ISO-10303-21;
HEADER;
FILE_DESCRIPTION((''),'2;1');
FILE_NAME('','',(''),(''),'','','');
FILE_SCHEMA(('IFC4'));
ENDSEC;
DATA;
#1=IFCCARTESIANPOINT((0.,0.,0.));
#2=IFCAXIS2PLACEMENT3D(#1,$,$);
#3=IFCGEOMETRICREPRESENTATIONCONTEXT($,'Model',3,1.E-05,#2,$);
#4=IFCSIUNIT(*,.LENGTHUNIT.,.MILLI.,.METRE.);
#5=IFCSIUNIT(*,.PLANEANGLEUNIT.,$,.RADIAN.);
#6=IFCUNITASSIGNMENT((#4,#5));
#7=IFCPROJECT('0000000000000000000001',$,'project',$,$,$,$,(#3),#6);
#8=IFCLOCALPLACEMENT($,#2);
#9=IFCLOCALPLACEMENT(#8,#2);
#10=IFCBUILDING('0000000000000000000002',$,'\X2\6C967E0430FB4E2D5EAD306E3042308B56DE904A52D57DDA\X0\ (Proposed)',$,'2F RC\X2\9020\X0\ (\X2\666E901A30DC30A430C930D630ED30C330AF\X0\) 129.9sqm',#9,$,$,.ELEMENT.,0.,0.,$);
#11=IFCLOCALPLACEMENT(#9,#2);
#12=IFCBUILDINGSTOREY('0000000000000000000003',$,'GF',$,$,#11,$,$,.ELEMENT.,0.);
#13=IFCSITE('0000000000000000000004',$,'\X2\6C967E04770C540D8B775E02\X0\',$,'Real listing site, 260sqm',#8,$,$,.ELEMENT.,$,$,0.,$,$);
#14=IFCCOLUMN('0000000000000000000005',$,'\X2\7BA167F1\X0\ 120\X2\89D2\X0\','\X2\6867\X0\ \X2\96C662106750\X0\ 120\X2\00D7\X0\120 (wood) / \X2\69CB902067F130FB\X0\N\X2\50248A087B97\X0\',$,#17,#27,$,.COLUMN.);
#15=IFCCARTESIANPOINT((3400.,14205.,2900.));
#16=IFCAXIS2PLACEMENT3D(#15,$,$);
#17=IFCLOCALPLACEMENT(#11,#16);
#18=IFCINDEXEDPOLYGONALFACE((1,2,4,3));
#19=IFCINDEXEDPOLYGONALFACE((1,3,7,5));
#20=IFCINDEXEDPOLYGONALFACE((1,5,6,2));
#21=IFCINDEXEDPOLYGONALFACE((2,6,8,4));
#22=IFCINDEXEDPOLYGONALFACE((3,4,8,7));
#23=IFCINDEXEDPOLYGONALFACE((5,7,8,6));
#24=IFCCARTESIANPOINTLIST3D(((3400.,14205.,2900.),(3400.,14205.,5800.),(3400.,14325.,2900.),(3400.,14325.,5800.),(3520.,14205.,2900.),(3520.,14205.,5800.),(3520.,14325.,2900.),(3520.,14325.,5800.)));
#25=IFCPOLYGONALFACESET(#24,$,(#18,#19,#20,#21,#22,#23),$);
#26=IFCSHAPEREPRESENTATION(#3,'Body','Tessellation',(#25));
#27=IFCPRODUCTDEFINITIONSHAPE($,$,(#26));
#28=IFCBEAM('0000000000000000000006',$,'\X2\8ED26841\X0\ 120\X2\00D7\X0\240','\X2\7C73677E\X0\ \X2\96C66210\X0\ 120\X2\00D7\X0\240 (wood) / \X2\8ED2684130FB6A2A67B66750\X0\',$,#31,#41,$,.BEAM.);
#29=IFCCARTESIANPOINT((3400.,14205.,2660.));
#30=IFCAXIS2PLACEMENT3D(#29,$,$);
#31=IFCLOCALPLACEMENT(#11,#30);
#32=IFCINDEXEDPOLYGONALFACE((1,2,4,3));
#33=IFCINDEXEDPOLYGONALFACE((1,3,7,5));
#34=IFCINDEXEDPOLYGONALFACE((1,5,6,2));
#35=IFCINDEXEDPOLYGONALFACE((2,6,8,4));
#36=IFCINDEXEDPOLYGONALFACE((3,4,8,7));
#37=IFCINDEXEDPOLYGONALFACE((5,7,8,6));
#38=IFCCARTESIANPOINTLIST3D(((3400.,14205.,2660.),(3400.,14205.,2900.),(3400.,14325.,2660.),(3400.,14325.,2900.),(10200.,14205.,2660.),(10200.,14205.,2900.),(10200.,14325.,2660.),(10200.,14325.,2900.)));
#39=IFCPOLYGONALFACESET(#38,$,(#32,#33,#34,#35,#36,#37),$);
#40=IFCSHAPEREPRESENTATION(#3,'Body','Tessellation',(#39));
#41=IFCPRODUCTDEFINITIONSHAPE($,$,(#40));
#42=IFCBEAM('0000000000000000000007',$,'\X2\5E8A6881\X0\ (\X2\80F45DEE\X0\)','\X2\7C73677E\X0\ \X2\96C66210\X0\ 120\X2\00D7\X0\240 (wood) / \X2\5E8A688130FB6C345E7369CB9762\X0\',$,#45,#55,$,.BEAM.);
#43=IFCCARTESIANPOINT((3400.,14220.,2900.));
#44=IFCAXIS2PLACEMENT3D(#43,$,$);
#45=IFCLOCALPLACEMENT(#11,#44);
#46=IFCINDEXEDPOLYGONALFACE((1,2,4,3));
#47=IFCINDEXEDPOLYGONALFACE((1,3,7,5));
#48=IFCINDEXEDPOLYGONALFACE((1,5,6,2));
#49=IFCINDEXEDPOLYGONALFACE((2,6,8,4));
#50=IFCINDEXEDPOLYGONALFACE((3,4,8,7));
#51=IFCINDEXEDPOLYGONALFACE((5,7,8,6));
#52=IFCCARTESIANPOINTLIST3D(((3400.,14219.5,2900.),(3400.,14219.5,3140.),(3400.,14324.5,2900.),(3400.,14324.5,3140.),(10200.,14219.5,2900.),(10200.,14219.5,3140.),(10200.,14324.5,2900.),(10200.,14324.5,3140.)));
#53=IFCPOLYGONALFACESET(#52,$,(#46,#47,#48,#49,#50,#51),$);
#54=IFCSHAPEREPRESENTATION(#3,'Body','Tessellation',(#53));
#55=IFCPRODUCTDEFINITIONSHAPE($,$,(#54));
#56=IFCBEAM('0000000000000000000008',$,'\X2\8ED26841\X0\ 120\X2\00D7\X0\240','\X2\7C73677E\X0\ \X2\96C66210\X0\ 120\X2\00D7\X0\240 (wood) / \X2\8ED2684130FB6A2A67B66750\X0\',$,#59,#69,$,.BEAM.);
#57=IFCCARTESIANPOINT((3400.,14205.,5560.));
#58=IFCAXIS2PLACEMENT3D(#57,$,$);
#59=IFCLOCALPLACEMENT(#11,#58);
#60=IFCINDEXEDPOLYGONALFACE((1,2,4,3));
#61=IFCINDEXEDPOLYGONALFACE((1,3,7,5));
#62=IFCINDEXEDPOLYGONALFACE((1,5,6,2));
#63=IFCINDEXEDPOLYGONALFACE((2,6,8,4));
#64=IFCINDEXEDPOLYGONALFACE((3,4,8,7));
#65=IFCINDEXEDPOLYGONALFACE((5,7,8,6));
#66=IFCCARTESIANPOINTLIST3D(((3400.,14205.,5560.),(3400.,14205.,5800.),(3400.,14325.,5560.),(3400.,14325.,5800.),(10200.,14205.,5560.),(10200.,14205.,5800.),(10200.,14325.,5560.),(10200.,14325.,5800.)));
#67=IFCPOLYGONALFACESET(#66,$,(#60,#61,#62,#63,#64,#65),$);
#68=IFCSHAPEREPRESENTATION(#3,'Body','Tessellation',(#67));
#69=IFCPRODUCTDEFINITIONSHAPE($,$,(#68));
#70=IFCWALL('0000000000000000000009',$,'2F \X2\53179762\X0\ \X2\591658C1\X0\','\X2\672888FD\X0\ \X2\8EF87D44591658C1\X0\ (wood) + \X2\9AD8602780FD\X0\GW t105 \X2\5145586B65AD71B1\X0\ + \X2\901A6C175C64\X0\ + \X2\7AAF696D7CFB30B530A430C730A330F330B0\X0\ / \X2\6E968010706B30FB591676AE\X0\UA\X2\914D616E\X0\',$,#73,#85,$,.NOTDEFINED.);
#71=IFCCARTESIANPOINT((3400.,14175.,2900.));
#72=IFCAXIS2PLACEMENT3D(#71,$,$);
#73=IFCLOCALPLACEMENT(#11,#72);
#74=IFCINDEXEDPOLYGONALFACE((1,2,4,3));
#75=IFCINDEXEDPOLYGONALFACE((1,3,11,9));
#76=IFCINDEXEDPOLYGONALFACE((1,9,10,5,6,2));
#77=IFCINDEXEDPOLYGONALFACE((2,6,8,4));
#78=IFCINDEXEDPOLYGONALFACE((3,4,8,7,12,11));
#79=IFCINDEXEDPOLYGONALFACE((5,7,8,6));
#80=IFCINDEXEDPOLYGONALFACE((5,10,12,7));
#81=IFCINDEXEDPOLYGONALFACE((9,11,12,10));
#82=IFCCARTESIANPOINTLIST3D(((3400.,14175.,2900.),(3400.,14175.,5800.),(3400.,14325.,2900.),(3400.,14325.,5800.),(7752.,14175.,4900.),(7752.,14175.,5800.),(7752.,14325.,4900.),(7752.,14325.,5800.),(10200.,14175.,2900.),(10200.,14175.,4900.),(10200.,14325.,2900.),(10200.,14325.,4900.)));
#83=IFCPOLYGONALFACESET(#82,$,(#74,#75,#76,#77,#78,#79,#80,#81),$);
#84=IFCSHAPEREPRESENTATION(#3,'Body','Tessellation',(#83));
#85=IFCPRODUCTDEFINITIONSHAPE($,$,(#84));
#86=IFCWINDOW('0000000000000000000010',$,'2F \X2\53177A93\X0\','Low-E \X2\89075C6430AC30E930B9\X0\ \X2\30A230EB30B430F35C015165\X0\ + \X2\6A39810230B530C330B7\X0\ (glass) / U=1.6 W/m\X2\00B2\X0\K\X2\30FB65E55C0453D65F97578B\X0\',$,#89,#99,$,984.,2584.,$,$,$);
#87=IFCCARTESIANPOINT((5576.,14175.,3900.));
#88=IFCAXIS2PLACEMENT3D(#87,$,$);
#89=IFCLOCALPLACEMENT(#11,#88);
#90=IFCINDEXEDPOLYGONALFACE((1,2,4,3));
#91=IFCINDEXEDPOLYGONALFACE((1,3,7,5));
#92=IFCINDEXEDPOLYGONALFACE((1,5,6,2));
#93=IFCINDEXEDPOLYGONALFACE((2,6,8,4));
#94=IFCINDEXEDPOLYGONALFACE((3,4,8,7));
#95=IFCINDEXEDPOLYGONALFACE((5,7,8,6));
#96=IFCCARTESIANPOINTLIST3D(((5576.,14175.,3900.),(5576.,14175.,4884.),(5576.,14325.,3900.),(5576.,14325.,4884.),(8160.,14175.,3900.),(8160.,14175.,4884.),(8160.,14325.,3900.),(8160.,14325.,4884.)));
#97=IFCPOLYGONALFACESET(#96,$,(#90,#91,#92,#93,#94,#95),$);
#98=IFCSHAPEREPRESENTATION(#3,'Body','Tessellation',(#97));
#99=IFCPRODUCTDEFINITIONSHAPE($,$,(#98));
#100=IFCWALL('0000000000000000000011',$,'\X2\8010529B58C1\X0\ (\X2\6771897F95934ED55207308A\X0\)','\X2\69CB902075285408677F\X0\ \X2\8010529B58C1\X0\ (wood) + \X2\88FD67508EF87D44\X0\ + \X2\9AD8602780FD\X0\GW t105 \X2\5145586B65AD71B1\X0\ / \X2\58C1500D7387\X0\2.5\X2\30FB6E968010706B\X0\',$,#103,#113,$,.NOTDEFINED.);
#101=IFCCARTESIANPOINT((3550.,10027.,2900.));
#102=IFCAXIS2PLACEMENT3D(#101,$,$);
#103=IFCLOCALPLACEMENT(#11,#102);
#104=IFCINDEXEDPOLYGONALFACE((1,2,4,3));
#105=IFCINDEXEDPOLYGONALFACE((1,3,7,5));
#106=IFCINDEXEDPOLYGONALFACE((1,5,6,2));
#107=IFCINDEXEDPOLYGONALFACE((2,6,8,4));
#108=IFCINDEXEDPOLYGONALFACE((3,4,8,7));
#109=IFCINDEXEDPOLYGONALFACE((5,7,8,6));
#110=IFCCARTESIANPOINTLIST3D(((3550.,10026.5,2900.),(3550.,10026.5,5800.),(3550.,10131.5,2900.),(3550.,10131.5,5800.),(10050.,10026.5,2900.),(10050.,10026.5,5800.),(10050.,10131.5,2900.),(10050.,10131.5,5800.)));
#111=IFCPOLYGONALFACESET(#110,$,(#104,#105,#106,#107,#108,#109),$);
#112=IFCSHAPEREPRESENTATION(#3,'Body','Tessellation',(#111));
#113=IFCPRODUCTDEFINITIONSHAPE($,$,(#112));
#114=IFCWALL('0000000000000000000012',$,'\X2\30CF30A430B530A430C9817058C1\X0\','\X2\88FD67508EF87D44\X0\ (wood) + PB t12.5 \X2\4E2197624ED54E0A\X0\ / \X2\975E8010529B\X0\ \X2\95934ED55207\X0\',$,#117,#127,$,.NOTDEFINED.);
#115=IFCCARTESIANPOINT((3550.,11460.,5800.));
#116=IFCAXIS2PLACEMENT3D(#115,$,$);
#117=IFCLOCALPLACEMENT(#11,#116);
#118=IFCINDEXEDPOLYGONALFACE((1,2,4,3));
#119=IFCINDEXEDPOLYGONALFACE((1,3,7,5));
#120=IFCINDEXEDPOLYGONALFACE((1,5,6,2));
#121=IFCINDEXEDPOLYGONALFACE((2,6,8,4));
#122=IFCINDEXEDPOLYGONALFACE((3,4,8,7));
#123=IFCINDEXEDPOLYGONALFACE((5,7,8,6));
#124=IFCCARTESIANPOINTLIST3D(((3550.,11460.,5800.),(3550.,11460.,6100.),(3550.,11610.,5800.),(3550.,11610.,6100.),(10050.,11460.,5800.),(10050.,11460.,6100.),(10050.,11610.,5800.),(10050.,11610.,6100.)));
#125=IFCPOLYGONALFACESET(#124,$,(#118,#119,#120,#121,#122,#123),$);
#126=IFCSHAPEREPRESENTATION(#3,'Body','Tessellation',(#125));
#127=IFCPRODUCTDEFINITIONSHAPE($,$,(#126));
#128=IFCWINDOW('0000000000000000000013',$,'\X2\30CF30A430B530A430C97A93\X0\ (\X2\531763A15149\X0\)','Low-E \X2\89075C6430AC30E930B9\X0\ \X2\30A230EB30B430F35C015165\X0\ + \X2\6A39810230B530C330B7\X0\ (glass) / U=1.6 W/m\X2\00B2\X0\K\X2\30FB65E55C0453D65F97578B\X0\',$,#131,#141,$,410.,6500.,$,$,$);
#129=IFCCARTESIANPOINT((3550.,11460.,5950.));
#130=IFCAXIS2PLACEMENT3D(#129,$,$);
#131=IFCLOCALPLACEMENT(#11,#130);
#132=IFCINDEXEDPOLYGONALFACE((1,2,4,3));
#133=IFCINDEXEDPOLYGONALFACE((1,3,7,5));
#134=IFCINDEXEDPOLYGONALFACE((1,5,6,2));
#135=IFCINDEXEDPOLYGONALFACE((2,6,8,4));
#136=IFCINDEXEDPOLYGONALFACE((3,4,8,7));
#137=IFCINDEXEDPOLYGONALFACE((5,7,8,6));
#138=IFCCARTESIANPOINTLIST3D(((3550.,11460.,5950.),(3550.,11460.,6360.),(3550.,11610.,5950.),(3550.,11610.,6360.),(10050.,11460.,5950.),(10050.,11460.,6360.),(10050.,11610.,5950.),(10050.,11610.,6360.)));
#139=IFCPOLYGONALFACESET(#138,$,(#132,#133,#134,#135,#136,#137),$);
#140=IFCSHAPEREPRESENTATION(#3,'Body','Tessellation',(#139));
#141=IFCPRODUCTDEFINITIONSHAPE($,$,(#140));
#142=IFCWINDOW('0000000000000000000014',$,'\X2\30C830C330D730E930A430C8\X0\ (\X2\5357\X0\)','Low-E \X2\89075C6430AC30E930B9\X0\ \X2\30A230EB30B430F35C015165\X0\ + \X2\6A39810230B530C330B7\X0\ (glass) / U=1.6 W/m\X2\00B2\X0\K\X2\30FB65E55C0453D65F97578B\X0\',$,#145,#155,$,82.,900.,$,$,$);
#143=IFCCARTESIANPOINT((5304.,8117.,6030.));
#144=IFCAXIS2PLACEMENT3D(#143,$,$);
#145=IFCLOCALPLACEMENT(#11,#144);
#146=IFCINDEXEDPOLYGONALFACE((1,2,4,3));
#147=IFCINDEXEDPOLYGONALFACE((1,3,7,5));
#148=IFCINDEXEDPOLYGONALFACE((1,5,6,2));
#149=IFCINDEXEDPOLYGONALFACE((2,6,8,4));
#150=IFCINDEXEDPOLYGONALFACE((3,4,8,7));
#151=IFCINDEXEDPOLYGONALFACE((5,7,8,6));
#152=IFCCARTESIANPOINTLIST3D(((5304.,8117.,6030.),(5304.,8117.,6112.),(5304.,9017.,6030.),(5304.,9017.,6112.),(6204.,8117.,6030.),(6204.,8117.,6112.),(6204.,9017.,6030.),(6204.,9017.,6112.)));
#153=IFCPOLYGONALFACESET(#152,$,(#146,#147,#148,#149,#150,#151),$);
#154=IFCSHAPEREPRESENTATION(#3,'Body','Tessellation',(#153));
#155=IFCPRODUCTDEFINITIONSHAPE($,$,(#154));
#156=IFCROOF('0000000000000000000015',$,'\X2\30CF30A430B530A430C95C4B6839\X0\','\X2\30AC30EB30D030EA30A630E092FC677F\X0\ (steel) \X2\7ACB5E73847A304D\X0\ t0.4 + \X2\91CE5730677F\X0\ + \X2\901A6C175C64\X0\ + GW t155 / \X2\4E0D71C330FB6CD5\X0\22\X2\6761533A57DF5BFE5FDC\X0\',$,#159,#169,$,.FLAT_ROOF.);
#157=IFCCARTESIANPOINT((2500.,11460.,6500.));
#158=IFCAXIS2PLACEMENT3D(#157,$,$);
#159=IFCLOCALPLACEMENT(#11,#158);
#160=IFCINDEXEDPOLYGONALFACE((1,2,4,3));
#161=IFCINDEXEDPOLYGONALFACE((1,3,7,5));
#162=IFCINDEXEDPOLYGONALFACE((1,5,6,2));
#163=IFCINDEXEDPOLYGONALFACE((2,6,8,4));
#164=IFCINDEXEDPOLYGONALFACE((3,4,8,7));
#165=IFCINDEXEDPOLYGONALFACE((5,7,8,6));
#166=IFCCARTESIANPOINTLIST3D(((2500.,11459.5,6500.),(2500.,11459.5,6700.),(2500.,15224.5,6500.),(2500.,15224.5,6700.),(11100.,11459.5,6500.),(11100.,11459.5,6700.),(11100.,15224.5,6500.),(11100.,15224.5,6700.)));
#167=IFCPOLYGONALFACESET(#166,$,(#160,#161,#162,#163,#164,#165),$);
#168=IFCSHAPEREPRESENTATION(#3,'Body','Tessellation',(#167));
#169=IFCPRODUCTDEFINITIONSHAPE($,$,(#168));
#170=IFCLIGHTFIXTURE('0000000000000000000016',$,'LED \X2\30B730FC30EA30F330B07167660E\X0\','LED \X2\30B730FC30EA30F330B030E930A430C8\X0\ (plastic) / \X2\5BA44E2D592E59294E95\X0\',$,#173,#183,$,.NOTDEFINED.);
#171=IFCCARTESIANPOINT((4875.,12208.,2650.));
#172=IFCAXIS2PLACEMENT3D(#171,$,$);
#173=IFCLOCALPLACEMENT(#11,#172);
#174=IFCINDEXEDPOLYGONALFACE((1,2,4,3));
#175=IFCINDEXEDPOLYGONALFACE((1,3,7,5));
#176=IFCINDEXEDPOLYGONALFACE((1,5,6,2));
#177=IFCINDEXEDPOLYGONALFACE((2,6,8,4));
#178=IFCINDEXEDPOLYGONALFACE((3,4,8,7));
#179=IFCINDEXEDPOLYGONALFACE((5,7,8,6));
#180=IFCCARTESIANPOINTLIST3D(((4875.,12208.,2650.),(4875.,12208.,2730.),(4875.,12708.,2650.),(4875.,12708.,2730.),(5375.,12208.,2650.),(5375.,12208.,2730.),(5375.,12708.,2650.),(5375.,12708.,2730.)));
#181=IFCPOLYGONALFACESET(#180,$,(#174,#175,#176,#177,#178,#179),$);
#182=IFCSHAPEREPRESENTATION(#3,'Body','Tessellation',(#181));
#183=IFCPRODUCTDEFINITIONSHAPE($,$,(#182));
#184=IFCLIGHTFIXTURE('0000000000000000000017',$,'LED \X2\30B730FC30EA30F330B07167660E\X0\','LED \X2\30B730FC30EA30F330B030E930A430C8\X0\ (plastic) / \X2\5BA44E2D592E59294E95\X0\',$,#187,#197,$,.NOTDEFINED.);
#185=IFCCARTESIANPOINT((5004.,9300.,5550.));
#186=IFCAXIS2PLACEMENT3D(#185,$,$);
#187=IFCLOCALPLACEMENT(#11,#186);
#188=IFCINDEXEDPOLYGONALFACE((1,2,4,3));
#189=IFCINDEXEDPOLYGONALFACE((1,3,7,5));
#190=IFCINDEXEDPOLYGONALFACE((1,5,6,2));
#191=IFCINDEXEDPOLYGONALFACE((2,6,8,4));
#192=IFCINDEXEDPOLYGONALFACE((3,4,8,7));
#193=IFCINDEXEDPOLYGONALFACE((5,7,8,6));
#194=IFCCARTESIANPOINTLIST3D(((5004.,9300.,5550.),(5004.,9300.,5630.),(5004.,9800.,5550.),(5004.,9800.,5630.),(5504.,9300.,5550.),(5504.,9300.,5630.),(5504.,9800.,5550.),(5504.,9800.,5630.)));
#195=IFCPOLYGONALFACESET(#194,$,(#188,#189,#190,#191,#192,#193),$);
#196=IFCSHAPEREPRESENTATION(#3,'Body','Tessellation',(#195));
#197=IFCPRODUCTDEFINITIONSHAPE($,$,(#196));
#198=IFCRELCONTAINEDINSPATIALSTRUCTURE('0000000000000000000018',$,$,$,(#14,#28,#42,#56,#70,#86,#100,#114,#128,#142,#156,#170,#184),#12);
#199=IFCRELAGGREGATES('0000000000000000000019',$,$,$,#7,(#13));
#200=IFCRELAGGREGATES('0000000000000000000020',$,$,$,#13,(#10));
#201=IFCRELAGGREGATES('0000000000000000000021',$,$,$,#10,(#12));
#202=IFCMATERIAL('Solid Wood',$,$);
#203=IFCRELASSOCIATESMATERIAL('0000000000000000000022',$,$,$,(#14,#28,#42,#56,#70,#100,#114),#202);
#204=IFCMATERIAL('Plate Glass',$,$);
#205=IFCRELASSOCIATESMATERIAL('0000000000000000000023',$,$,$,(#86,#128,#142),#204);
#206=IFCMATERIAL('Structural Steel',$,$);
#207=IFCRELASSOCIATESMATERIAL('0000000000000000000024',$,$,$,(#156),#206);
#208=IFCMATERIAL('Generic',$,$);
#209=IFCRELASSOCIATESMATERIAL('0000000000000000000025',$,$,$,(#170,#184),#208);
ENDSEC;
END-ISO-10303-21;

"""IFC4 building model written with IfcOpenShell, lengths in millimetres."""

from ifc_helpers import new_model, si_unit, frame, frame_2d, origin, place, context, project, spatial, rectangle, extrude, material, element, fill, save


model = new_model("IFC4")

# Units and contexts
model_context = context("Model", 3, precision=1e-05, world=origin())
ifc_project = project(units=[si_unit("LENGTHUNIT", "METRE", prefix="MILLI"), si_unit("PLANEANGLEUNIT", "RADIAN")], contexts=[model_context])

# Site, building, storey
site_placement = place(None, origin())
site = spatial("IfcSite", under=ifc_project, at=site_placement, Name="沖縄県名護市", ObjectType="Real listing site, 260sqm", CompositionType="ELEMENT", RefElevation=0.0)
building_placement = place(site_placement, origin())
building = spatial("IfcBuilding", under=site, at=building_placement, Name="沖縄・中庭のある回遊動線 (Proposed)", ObjectType="2F RC造 (普通ボイドブロック) 129.9sqm", CompositionType="ELEMENT", ElevationOfRefHeight=0.0, ElevationOfTerrain=0.0)
storey_placement = place(building_placement, origin())
storey = spatial("IfcBuildingStorey", under=building, at=storey_placement, Name="GF", CompositionType="ELEMENT", Elevation=0.0)

# Column
ifc_material_1 = material(Name="Solid Wood")
column_1_placement = place(storey_placement, frame((3400.0, 14205.0, 2900.0)))
element("IfcColumn", 1, at=column_1_placement, inside=storey, material=ifc_material_1, Name="管柱 120角", Description="桧 集成材 120×120 (wood) / 構造柱・N値計算", PredefinedType="COLUMN", context=model_context, shape_type="SweptSolid", body=[
    extrude(rectangle(XDim=120.0, YDim=120.0, at=frame_2d((60.0, 60.0))), frame((3400.0, 14205.0, 2900.0)), (0.0, 0.0, 1.0), 2900.0),
])

# Beams
beam_1_placement = place(storey_placement, frame((3400.0, 14205.0, 2660.0)))
element("IfcBeam", 2, at=beam_1_placement, inside=storey, material=ifc_material_1, Name="軒桁 120×240", Description="米松 集成 120×240 (wood) / 軒桁・横架材", PredefinedType="BEAM", context=model_context, shape_type="SweptSolid", body=[
    extrude(rectangle(XDim=6800.0, YDim=120.0, at=frame_2d((3400.0, 60.0))), frame((3400.0, 14205.0, 2660.0)), (0.0, 0.0, 1.0), 240.0),
])
beam_2_placement = place(storey_placement, frame((3400.0, 14220.0, 2900.0)))
element("IfcBeam", 3, at=beam_2_placement, inside=storey, material=ifc_material_1, Name="床梁 (胴差)", Description="米松 集成 120×240 (wood) / 床梁・水平構面", PredefinedType="BEAM", context=model_context, shape_type="SweptSolid", body=[
    extrude(rectangle(XDim=6800.0, YDim=105.0, at=frame_2d((3400.0, 52.0))), frame((3400.0, 14220.0, 2900.0)), (0.0, 0.0, 1.0), 240.0),
])
beam_3_placement = place(storey_placement, frame((3400.0, 14205.0, 5560.0)))
element("IfcBeam", 4, at=beam_3_placement, inside=storey, material=ifc_material_1, Name="軒桁 120×240", Description="米松 集成 120×240 (wood) / 軒桁・横架材", PredefinedType="BEAM", context=model_context, shape_type="SweptSolid", body=[
    extrude(rectangle(XDim=6800.0, YDim=120.0, at=frame_2d((3400.0, 60.0))), frame((3400.0, 14205.0, 5560.0)), (0.0, 0.0, 1.0), 240.0),
])

# Wall, opening, window
wall_1_placement = place(storey_placement, frame((3400.0, 14175.0, 2900.0)))
wall_1 = element("IfcWall", 5, at=wall_1_placement, inside=storey, material=ifc_material_1, Name="2F 北面 外壁", Description="木製 軸組外壁 (wood) + 高性能GW t105 充填断熱 + 通気層 + 窯業系サイディング / 準耐火・外皮UA配慮", PredefinedType="NOTDEFINED", context=model_context, shape_type="SweptSolid", body=[
    extrude(rectangle(XDim=6800.0, YDim=150.0, at=frame_2d((3400.0, 75.0))), frame((3400.0, 14175.0, 2900.0)), (0.0, 0.0, 1.0), 2900.0),
])
opening_1_placement = place(storey_placement, frame((5576.0, 14175.0, 3900.0)))
opening_1 = element("IfcOpeningElement", 6, at=opening_1_placement, cuts=wall_1, PredefinedType="NOTDEFINED", context=model_context, shape_type="SweptSolid", body=[
    extrude(rectangle(XDim=2584.0, YDim=150.0, at=frame_2d((1292.0, 75.0))), frame((5576.0, 14175.0, 3900.0)), (0.0, 0.0, 1.0), 984.0),
])
ifc_material_2 = material(Name="Plate Glass")
window_1_placement = place(storey_placement, frame((5576.0, 14175.0, 3900.0)))
window_1 = element("IfcWindow", 7, at=window_1_placement, inside=storey, material=ifc_material_2, Name="2F 北窓", Description="Low-E 複層ガラス アルゴン封入 + 樹脂サッシ (glass) / U=1.6 W/m²K・日射取得型", OverallHeight=984.0, OverallWidth=2584.0, context=model_context, shape_type="SweptSolid", body=[
    extrude(rectangle(XDim=2584.0, YDim=150.0, at=frame_2d((1292.0, 75.0))), frame((5576.0, 14175.0, 3900.0)), (0.0, 0.0, 1.0), 984.0),
])
fill(opening_1, window_1)

# Wall
wall_2_placement = place(storey_placement, frame((3550.0, 10027.0, 2900.0)))
element("IfcWall", 8, at=wall_2_placement, inside=storey, material=ifc_material_1, Name="耐力壁 (東西間仕切り)", Description="構造用合板 耐力壁 (wood) + 製材軸組 + 高性能GW t105 充填断熱 / 壁倍率2.5・準耐火", PredefinedType="NOTDEFINED", context=model_context, shape_type="SweptSolid", body=[
    extrude(rectangle(XDim=6500.0, YDim=105.0, at=frame_2d((3250.0, 52.0))), frame((3550.0, 10027.0, 2900.0)), (0.0, 0.0, 1.0), 2900.0),
])

# Wall, opening, window
wall_3_placement = place(storey_placement, frame((3550.0, 11460.0, 5800.0)))
wall_3 = element("IfcWall", 9, at=wall_3_placement, inside=storey, material=ifc_material_1, Name="ハイサイド腰壁", Description="製材軸組 (wood) + PB t12.5 両面仕上 / 非耐力 間仕切", PredefinedType="NOTDEFINED", context=model_context, shape_type="SweptSolid", body=[
    extrude(rectangle(XDim=6500.0, YDim=150.0, at=frame_2d((3250.0, 75.0))), frame((3550.0, 11460.0, 5800.0)), (0.0, 0.0, 1.0), 700.0),
])
opening_2_placement = place(storey_placement, frame((3550.0, 11460.0, 5950.0)))
opening_2 = element("IfcOpeningElement", 10, at=opening_2_placement, cuts=wall_3, PredefinedType="NOTDEFINED", context=model_context, shape_type="SweptSolid", body=[
    extrude(rectangle(XDim=6500.0, YDim=150.0, at=frame_2d((3250.0, 75.0))), frame((3550.0, 11460.0, 5950.0)), (0.0, 0.0, 1.0), 410.0),
])
window_2_placement = place(storey_placement, frame((3550.0, 11460.0, 5950.0)))
window_2 = element("IfcWindow", 11, at=window_2_placement, inside=storey, material=ifc_material_2, Name="ハイサイド窓 (北採光)", Description="Low-E 複層ガラス アルゴン封入 + 樹脂サッシ (glass) / U=1.6 W/m²K・日射取得型", OverallHeight=410.0, OverallWidth=6500.0, context=model_context, shape_type="SweptSolid", body=[
    extrude(rectangle(XDim=6500.0, YDim=150.0, at=frame_2d((3250.0, 75.0))), frame((3550.0, 11460.0, 5950.0)), (0.0, 0.0, 1.0), 410.0),
])
fill(opening_2, window_2)

# Window
window_3_placement = place(storey_placement, frame((5304.0, 8117.0, 6030.0)))
element("IfcWindow", 12, at=window_3_placement, inside=storey, material=ifc_material_2, Name="トップライト (南)", Description="Low-E 複層ガラス アルゴン封入 + 樹脂サッシ (glass) / U=1.6 W/m²K・日射取得型", OverallHeight=82.0, OverallWidth=900.0, context=model_context, shape_type="SweptSolid", body=[
    extrude(rectangle(XDim=900.0, YDim=900.0, at=frame_2d((450.0, 450.0))), frame((5304.0, 8117.0, 6030.0)), (0.0, 0.0, 1.0), 82.0),
])

# Roof
ifc_material_3 = material(Name="Structural Steel")
roof_placement = place(storey_placement, frame((2500.0, 11460.0, 6500.0)))
element("IfcRoof", 13, at=roof_placement, inside=storey, material=ifc_material_3, Name="ハイサイド屋根", Description="ガルバリウム鋼板 (steel) 立平葺き t0.4 + 野地板 + 通気層 + GW t155 / 不燃・法22条区域対応", PredefinedType="FLAT_ROOF", context=model_context, shape_type="SweptSolid", body=[
    extrude(rectangle(XDim=8600.0, YDim=3765.0, at=frame_2d((4300.0, 1882.0))), frame((2500.0, 11460.0, 6500.0)), (0.0, 0.0, 1.0), 200.0),
])

# Light fixtures
ifc_material_4 = material(Name="Generic")
light_fixture_1_placement = place(storey_placement, frame((4875.0, 12208.0, 2650.0)))
element("IfcLightFixture", 14, at=light_fixture_1_placement, inside=storey, material=ifc_material_4, Name="LED シーリング照明", Description="LED シーリングライト (plastic) / 室中央天井", PredefinedType="NOTDEFINED", context=model_context, shape_type="SweptSolid", body=[
    extrude(rectangle(XDim=500.0, YDim=500.0, at=frame_2d((250.0, 250.0))), frame((4875.0, 12208.0, 2650.0)), (0.0, 0.0, 1.0), 80.0),
])
light_fixture_2_placement = place(storey_placement, frame((5004.0, 9300.0, 5550.0)))
element("IfcLightFixture", 15, at=light_fixture_2_placement, inside=storey, material=ifc_material_4, Name="LED シーリング照明", Description="LED シーリングライト (plastic) / 室中央天井", PredefinedType="NOTDEFINED", context=model_context, shape_type="SweptSolid", body=[
    extrude(rectangle(XDim=500.0, YDim=500.0, at=frame_2d((250.0, 250.0))), frame((5004.0, 9300.0, 5550.0)), (0.0, 0.0, 1.0), 80.0),
])

save(model, "model.ifc")
